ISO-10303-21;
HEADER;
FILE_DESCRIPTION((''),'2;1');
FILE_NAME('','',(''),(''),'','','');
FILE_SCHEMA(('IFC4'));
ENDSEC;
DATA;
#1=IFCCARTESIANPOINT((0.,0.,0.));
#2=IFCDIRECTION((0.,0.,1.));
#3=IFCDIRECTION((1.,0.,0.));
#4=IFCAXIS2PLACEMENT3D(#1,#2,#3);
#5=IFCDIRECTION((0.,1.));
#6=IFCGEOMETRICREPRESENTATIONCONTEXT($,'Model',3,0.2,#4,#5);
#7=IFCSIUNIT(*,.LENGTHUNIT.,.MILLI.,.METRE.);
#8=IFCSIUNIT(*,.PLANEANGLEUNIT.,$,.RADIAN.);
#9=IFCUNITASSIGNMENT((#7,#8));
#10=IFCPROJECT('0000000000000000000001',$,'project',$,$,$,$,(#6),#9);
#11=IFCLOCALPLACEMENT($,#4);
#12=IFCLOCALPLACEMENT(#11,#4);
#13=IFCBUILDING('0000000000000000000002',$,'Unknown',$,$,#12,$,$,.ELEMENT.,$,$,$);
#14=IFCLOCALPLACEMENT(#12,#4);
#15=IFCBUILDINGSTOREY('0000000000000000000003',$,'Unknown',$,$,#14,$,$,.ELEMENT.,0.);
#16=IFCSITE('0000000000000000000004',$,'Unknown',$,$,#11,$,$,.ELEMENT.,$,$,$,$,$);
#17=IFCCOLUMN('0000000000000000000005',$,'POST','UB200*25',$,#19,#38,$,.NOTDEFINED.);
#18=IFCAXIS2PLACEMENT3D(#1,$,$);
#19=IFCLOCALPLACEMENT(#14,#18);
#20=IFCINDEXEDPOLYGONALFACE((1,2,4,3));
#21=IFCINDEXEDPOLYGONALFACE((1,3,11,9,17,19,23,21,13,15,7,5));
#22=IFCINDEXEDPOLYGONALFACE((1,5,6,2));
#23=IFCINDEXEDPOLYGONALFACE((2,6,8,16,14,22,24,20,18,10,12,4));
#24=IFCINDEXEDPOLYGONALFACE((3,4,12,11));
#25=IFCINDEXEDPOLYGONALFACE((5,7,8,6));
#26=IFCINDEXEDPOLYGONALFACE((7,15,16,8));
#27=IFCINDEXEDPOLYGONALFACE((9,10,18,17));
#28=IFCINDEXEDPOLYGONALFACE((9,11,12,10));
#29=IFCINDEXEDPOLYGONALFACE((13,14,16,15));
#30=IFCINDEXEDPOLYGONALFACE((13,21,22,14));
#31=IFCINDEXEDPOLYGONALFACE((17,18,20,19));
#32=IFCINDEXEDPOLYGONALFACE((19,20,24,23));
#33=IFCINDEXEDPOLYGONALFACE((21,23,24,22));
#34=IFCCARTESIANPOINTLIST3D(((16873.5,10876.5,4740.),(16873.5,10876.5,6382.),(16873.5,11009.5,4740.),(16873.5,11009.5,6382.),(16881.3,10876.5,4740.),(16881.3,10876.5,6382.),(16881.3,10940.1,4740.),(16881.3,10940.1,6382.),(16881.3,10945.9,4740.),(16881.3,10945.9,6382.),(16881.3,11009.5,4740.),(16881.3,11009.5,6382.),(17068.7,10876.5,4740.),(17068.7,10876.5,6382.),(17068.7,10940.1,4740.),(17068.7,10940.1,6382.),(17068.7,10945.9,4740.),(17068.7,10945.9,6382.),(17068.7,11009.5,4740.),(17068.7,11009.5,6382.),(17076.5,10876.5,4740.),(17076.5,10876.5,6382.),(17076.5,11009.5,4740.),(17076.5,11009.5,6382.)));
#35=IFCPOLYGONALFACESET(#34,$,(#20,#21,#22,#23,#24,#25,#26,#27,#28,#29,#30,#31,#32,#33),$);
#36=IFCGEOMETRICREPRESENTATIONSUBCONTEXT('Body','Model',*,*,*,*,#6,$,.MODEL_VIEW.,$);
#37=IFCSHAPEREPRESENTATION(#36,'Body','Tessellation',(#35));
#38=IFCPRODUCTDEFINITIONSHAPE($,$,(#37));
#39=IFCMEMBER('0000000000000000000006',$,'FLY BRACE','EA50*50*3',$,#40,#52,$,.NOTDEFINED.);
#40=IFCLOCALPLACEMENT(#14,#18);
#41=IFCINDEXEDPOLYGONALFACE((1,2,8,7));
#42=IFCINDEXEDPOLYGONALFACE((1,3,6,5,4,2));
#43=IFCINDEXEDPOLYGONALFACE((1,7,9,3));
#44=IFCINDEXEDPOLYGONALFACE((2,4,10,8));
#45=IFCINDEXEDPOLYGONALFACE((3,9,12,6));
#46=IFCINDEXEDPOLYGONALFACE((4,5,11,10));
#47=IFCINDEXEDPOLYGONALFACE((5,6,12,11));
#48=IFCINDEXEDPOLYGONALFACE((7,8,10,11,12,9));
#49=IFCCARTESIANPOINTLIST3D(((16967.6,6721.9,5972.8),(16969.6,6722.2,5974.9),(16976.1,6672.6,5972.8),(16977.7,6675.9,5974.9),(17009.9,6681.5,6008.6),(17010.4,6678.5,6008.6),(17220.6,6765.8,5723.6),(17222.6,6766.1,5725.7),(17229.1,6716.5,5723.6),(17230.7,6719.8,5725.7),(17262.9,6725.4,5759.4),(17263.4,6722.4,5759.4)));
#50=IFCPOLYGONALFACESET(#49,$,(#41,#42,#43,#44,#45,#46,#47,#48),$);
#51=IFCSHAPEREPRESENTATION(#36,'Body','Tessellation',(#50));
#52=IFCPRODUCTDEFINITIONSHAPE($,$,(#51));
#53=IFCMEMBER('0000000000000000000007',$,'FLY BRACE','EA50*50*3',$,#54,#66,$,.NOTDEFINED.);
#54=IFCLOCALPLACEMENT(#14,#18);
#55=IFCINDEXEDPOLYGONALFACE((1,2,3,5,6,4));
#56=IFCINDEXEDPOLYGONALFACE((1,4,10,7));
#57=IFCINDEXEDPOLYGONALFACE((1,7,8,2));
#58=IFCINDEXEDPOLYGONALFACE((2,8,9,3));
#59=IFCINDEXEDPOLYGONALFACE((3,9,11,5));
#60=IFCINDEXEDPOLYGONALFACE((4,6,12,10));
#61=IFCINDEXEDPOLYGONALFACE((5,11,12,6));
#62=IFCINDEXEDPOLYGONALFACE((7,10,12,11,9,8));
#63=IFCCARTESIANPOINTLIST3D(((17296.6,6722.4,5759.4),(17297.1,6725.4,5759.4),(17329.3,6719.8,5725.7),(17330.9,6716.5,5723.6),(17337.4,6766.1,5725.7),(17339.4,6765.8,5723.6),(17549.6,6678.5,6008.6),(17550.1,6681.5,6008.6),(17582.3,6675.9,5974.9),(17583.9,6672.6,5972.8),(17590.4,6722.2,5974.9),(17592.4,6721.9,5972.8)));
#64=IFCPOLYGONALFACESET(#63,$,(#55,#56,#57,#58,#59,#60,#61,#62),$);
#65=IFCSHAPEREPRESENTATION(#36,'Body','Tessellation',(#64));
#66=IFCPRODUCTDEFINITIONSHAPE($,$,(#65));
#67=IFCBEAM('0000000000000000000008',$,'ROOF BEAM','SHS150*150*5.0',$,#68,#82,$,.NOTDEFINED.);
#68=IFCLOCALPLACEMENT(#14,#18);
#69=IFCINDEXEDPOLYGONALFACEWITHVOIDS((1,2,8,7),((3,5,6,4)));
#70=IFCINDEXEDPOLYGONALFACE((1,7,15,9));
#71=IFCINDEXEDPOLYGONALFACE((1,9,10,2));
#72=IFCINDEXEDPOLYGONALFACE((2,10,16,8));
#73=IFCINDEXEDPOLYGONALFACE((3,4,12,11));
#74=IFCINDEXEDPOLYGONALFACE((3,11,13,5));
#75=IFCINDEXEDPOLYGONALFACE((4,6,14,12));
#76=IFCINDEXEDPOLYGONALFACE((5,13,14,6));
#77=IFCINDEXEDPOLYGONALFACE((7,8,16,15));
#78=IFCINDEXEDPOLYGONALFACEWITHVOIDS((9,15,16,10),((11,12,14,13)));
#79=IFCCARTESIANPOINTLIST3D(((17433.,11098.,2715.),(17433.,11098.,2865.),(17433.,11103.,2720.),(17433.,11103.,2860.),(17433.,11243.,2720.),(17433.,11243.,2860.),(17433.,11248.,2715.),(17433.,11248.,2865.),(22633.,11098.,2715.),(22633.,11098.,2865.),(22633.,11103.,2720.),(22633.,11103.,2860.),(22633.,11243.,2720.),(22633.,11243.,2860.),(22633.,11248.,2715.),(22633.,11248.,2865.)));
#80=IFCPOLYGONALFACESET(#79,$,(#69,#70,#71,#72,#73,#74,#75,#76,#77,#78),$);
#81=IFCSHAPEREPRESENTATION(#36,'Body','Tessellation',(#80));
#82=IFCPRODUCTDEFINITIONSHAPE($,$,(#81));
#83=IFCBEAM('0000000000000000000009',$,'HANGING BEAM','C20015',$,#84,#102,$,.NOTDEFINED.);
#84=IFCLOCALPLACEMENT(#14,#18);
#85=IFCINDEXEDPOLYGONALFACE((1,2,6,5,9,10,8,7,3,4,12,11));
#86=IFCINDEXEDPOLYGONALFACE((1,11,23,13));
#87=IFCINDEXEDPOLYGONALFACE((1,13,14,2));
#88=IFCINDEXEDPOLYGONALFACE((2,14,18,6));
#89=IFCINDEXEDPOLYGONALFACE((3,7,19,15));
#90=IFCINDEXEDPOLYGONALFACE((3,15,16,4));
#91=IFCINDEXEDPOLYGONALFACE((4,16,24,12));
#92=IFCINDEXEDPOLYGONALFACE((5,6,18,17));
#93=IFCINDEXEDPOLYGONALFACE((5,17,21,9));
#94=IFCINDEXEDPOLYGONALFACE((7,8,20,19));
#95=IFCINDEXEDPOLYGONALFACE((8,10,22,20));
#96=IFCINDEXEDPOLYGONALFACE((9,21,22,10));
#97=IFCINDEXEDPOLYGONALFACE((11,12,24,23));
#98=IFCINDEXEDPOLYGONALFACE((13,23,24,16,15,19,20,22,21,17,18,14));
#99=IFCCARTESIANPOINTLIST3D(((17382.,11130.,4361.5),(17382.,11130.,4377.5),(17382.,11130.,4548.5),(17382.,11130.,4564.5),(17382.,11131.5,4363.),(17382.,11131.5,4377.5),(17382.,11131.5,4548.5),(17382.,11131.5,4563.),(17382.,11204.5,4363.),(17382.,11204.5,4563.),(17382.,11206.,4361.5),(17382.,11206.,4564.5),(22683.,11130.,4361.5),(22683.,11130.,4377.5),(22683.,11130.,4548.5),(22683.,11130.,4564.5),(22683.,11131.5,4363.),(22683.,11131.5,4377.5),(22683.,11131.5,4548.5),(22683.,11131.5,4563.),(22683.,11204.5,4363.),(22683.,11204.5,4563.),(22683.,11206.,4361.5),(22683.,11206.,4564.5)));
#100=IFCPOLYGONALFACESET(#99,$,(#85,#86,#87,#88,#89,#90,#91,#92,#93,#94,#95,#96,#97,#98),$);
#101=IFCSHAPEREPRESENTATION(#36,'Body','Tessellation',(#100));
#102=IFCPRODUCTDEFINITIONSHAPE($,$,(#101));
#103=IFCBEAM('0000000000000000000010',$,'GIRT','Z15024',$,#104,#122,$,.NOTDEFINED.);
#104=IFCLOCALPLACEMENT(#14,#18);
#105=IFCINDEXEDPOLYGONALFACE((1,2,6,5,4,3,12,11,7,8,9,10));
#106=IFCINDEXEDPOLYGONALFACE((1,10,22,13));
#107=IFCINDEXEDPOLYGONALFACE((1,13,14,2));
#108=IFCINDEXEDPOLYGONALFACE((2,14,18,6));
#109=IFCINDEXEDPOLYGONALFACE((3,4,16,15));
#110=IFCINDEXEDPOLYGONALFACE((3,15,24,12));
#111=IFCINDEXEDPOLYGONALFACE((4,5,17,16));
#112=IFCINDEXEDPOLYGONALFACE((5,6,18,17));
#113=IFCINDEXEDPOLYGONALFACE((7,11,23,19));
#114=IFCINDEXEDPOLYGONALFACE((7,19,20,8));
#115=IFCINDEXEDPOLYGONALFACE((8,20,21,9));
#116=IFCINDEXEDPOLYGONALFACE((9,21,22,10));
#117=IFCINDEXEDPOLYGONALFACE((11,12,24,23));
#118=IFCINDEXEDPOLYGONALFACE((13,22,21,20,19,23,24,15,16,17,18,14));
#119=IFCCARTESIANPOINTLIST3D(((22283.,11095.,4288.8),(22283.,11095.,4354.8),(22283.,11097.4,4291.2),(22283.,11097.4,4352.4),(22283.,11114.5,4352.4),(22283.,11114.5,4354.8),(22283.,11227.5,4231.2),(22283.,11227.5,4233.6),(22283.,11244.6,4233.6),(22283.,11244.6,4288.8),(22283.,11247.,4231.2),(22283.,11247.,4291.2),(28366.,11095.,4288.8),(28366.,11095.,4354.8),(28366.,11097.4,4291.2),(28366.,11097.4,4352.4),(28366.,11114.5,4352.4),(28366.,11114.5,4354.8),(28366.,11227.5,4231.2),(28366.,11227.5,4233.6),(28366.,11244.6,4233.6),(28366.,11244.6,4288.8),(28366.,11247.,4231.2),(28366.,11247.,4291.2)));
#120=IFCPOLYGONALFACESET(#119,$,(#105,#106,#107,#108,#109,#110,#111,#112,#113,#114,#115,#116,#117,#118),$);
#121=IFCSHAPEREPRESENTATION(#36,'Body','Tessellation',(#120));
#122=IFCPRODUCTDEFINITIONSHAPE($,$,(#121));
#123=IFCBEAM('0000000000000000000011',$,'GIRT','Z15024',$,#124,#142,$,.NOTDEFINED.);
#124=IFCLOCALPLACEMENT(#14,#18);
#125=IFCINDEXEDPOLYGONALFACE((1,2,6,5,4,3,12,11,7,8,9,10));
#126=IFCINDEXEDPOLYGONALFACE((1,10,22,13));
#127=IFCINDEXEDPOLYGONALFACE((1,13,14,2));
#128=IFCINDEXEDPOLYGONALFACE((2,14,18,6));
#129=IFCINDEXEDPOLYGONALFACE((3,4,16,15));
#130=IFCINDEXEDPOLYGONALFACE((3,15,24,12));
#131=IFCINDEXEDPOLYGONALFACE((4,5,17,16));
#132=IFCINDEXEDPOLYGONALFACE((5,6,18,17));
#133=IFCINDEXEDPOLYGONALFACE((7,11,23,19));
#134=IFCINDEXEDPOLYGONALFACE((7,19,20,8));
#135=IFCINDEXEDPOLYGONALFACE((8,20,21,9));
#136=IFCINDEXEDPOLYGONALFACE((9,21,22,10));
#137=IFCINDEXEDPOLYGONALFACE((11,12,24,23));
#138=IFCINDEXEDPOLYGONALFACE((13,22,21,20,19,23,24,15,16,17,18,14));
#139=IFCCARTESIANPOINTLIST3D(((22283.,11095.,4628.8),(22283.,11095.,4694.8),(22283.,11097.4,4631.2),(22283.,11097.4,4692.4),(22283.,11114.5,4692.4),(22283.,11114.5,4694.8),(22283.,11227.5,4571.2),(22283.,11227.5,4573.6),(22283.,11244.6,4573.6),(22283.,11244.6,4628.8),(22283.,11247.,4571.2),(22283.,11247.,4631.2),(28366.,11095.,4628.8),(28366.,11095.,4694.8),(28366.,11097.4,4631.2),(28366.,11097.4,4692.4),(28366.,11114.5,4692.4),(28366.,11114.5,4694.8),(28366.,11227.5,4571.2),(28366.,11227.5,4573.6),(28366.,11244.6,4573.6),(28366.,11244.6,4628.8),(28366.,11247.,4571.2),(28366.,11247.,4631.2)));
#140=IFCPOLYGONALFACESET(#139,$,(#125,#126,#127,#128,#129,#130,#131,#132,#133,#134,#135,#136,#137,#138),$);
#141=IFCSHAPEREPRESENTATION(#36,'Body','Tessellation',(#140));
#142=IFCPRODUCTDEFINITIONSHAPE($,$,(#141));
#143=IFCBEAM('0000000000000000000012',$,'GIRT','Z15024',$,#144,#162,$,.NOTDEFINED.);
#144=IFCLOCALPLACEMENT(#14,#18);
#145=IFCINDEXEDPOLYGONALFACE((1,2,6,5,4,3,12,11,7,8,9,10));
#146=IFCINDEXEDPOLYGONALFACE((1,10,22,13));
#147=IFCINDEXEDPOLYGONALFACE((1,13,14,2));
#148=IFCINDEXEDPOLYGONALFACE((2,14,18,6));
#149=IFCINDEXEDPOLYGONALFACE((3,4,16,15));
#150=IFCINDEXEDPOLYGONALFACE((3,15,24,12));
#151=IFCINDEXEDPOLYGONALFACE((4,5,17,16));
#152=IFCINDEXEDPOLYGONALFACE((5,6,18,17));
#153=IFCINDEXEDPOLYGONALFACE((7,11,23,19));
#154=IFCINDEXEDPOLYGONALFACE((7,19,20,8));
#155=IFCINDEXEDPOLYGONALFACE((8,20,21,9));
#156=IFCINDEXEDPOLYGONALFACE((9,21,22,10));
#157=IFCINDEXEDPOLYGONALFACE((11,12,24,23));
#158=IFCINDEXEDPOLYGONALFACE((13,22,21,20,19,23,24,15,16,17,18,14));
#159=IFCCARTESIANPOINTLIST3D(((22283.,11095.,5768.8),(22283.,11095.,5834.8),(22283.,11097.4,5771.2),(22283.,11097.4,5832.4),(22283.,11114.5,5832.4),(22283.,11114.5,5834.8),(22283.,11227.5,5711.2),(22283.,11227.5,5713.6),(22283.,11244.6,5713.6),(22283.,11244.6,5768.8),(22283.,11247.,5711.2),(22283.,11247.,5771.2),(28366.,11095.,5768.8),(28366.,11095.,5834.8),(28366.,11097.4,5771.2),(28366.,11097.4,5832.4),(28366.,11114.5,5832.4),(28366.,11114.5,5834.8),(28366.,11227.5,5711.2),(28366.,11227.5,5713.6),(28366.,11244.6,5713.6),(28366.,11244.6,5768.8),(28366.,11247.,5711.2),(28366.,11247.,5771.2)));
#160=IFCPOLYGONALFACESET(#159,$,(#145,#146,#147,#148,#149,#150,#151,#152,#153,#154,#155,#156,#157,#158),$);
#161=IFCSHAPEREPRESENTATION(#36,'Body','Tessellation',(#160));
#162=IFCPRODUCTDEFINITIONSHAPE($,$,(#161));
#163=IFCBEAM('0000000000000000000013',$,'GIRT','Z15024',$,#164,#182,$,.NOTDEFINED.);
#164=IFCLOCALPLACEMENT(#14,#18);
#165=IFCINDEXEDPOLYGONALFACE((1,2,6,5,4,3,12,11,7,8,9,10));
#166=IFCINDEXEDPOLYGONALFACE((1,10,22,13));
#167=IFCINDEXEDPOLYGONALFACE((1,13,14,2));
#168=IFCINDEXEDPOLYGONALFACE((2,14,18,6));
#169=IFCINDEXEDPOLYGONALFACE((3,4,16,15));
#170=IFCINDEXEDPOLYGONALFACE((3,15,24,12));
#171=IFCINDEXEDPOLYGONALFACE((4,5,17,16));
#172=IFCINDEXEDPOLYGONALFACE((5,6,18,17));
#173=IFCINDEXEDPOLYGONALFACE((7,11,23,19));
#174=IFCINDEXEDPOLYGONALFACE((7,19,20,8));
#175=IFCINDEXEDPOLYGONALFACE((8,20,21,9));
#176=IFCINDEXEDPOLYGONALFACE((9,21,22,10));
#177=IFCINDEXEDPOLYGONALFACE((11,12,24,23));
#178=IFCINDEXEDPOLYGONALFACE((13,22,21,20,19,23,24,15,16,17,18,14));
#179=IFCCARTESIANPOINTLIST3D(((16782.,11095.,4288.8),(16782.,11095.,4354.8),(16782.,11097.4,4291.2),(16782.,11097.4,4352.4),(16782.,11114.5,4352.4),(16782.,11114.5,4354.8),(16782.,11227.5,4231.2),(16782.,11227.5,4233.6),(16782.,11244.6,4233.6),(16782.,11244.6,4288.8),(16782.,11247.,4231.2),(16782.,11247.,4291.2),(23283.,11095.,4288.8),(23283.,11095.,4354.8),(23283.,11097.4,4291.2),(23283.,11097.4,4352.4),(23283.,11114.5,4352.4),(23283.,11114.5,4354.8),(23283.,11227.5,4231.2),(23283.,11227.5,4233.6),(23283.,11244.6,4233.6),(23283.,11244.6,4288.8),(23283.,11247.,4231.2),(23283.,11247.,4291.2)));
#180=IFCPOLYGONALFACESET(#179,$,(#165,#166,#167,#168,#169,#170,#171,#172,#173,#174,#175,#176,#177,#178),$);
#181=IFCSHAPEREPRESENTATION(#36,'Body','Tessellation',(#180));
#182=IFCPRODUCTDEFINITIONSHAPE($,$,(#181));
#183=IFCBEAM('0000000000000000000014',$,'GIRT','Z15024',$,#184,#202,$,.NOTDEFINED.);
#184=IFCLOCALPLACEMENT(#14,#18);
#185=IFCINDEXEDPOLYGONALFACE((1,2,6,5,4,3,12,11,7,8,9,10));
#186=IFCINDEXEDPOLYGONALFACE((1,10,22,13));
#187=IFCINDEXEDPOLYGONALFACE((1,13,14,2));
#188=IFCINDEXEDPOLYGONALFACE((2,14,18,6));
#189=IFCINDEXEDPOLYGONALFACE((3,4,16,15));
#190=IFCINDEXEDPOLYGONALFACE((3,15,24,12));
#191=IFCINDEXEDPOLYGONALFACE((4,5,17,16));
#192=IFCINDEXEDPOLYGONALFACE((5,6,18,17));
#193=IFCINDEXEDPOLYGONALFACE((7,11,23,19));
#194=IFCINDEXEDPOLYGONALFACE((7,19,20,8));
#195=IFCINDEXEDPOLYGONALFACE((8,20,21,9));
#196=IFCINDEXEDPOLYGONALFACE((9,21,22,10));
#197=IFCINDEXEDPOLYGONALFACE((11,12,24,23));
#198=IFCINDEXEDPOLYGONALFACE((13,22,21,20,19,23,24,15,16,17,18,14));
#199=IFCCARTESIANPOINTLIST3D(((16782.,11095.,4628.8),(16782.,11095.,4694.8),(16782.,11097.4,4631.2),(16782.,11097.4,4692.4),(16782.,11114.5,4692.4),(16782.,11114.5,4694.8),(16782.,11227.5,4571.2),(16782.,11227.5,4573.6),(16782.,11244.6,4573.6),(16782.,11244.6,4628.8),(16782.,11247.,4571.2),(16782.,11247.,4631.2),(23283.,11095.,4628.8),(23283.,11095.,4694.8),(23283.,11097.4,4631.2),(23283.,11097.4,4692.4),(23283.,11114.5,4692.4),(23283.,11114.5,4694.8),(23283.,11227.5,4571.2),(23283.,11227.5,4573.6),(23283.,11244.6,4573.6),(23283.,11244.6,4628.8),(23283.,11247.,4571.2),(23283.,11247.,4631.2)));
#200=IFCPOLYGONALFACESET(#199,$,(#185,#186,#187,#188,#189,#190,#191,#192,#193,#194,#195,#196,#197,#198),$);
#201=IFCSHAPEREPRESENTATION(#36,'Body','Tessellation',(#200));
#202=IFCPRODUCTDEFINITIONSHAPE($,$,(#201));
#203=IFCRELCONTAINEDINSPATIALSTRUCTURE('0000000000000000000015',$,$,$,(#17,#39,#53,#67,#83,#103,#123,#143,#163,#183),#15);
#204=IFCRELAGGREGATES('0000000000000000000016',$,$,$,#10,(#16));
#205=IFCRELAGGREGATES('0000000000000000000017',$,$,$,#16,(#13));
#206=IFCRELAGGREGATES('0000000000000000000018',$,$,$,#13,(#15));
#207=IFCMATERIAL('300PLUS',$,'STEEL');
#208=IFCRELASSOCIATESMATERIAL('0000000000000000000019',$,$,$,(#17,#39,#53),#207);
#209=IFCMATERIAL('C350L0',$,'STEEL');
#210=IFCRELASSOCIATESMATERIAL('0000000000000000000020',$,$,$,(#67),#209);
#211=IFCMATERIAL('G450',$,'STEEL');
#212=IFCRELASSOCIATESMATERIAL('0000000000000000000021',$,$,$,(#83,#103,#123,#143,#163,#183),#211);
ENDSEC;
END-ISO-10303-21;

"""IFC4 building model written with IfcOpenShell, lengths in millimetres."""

from ifc_helpers import new_model, si_unit, direction, frame, origin_with_axes, place, context, subcontext, project, spatial, line, indexed_curve, outline, extrude, material, element, save


model = new_model("IFC4")

# Units and contexts
model_context = context("Model", 3, precision=0.2, world=origin_with_axes(), true_north=direction((0.0, 1.0)))
body_context = subcontext(model_context, "Body", "Model", "MODEL_VIEW")
ifc_project = project(units=[si_unit("LENGTHUNIT", "METRE", prefix="MILLI"), si_unit("PLANEANGLEUNIT", "RADIAN")], contexts=[model_context])

# Site, building, storey
site_placement = place(None, origin_with_axes())
site = spatial("IfcSite", under=ifc_project, at=site_placement, Name="Unknown", CompositionType="ELEMENT")
building_placement = place(site_placement, origin_with_axes())
building = spatial("IfcBuilding", under=site, at=building_placement, Name="Unknown", CompositionType="ELEMENT")
storey_placement = place(building_placement, origin_with_axes())
storey = spatial("IfcBuildingStorey", under=building, at=storey_placement, Name="Unknown", CompositionType="ELEMENT", Elevation=0.0)

# Column
ifc_material_1 = material(Name="300PLUS", Category="STEEL")
column_placement = place(storey_placement, frame((16975.0, 10943.0, 4740.0), z_axis=(0.0, -1.0, 0.0), x_axis=(0.0, 0.0, 1.0)))
element("IfcColumn", 1, at=column_placement, inside=storey, material=ifc_material_1, Name="POST", Description="UB200*25", PredefinedType="NOTDEFINED", context=body_context, shape_type="SolidModel", body=[
    extrude(outline(indexed_curve([(-66.5, -101.5), (66.5, -101.5), (66.5, -93.7), (2.9, -93.7), (2.9, 93.7), (66.5, 93.7), (66.5, 101.5), (-66.5, 101.5), (-66.5, 93.7), (-2.9, 93.7), (-2.9, -93.7), (-66.5, -93.7)], segments=[line(1, 2, 3, 4, 5, 6, 7, 8, 9, 10, 11, 12, 1)])), frame((0.0, 0.0, 0.0), z_axis=(-1.0, 0.0, 0.0), x_axis=(0.0, 0.0, 1.0)), (0.0, 0.0, -1.0), 1642.0),
])

# Members
for number, where, z_axis, x_axis, name in (
    (2, (16989.0, 6700.2, 5990.7), (0.686182, 0.119065, 0.71762), (0.707055, 0.122687, -0.696435), "FLY BRACE"),
    (3, (17571.0, 6700.2, 5990.7), (0.170963, 0.985277, 0.0), (-0.707055, 0.122687, -0.696435), "FLY BRACE"),
):
    element("IfcMember", number, at=place(storey_placement, frame(where, z_axis=z_axis, x_axis=x_axis)), inside=storey, material=ifc_material_1, Name=name, Description="EA50*50*3", PredefinedType="NOTDEFINED", context=body_context, shape_type="SolidModel", body=[
        extrude(outline(indexed_curve([(-25.0, -25.0), (25.0, -25.0), (25.0, -22.0), (-22.0, -22.0), (-22.0, 25.0), (-25.0, 25.0)], segments=[line(1, 2, 3, 4, 5, 6, 1)])), frame((0.0, 0.0, 0.0), z_axis=(-1.0, 0.0, 0.0), x_axis=(0.0, 0.0, 1.0)), (0.0, 0.0, -1.0), 357.8),
    ])

# Beams
ifc_material_2 = material(Name="C350L0", Category="STEEL")
beam_1_placement = place(storey_placement, frame((17433.0, 11173.0, 2790.0), z_axis=(0.0, 0.0, 1.0), x_axis=(1.0, 0.0, 0.0)))
element("IfcBeam", 4, at=beam_1_placement, inside=storey, material=ifc_material_2, Name="ROOF BEAM", Description="SHS150*150*5.0", PredefinedType="NOTDEFINED", context=body_context, shape_type="SolidModel", body=[
    extrude(outline(indexed_curve([(-75.0, -75.0), (75.0, -75.0), (75.0, 75.0), (-75.0, 75.0)], segments=[line(1, 2, 3, 4, 1)]), holes=[indexed_curve([(-70.0, -70.0), (-70.0, 70.0), (70.0, 70.0), (70.0, -70.0)], segments=[line(1, 2, 3, 4, 1)])]), frame((0.0, 0.0, 0.0), z_axis=(-1.0, 0.0, 0.0), x_axis=(0.0, 0.0, 1.0)), (0.0, 0.0, -1.0), 5200.0),
])
ifc_material_3 = material(Name="G450", Category="STEEL")
beam_2_placement = place(storey_placement, frame((17382.0, 11168.0, 4463.0), z_axis=(0.0, -1.0, 0.0), x_axis=(1.0, 0.0, 0.0)))
element("IfcBeam", 5, at=beam_2_placement, inside=storey, material=ifc_material_3, Name="HANGING BEAM", Description="C20015", PredefinedType="NOTDEFINED", context=body_context, shape_type="SolidModel", body=[
    extrude(outline(indexed_curve([(38.0, -101.5), (38.0, -85.5), (36.5, -85.5), (36.5, -100.0), (-36.5, -100.0), (-36.5, 100.0), (36.5, 100.0), (36.5, 85.5), (38.0, 85.5), (38.0, 101.5), (-38.0, 101.5), (-38.0, -101.5)], segments=[line(1, 2, 3, 4, 5, 6, 7, 8, 9, 10, 11, 12, 1)])), frame((0.0, 0.0, 0.0), z_axis=(-1.0, 0.0, 0.0), x_axis=(0.0, 0.0, 1.0)), (0.0, 0.0, -1.0), 5301.0),
])
for number, where, z_axis, x_axis, name in (
    (6, (22283.0, 11171.0, 4290.0), (0.0, 0.0, -1.0), (1.0, 0.0, 0.0), "GIRT"),
    (7, (22283.0, 11171.0, 4630.0), (0.0, 0.0, -1.0), (1.0, 0.0, 0.0), "GIRT"),
    (8, (22283.0, 11171.0, 5770.0), (0.0, 0.0, -1.0), (1.0, 0.0, 0.0), "GIRT"),
):
    element("IfcBeam", number, at=place(storey_placement, frame(where, z_axis=z_axis, x_axis=x_axis)), inside=storey, material=ifc_material_3, Name=name, Description="Z15024", PredefinedType="NOTDEFINED", context=body_context, shape_type="SolidModel", body=[
        extrude(outline(indexed_curve([(58.8, -76.0), (58.8, -56.5), (56.4, -56.5), (56.4, -73.6), (1.2, -73.6), (1.2, 76.0), (-64.8, 76.0), (-64.8, 56.5), (-62.4, 56.5), (-62.4, 73.6), (-1.2, 73.6), (-1.2, -76.0)], segments=[line(1, 2, 3, 4, 5, 6, 7, 8, 9, 10, 11, 12, 1)])), frame((0.0, 0.0, 0.0), z_axis=(-1.0, 0.0, 0.0), x_axis=(0.0, 0.0, 1.0)), (0.0, 0.0, -1.0), 6083.0),
    ])
for number, where, z_axis, x_axis, name in (
    (9, (16782.0, 11171.0, 4290.0), (0.0, 0.0, -1.0), (1.0, 0.0, 0.0), "GIRT"),
    (10, (16782.0, 11171.0, 4630.0), (0.0, 0.0, -1.0), (1.0, 0.0, 0.0), "GIRT"),
):
    element("IfcBeam", number, at=place(storey_placement, frame(where, z_axis=z_axis, x_axis=x_axis)), inside=storey, material=ifc_material_3, Name=name, Description="Z15024", PredefinedType="NOTDEFINED", context=body_context, shape_type="SolidModel", body=[
        extrude(outline(indexed_curve([(58.8, -76.0), (58.8, -56.5), (56.4, -56.5), (56.4, -73.6), (1.2, -73.6), (1.2, 76.0), (-64.8, 76.0), (-64.8, 56.5), (-62.4, 56.5), (-62.4, 73.6), (-1.2, 73.6), (-1.2, -76.0)], segments=[line(1, 2, 3, 4, 5, 6, 7, 8, 9, 10, 11, 12, 1)])), frame((0.0, 0.0, 0.0), z_axis=(-1.0, 0.0, 0.0), x_axis=(0.0, 0.0, 1.0)), (0.0, 0.0, -1.0), 6501.0),
    ])

save(model, "model.ifc")
